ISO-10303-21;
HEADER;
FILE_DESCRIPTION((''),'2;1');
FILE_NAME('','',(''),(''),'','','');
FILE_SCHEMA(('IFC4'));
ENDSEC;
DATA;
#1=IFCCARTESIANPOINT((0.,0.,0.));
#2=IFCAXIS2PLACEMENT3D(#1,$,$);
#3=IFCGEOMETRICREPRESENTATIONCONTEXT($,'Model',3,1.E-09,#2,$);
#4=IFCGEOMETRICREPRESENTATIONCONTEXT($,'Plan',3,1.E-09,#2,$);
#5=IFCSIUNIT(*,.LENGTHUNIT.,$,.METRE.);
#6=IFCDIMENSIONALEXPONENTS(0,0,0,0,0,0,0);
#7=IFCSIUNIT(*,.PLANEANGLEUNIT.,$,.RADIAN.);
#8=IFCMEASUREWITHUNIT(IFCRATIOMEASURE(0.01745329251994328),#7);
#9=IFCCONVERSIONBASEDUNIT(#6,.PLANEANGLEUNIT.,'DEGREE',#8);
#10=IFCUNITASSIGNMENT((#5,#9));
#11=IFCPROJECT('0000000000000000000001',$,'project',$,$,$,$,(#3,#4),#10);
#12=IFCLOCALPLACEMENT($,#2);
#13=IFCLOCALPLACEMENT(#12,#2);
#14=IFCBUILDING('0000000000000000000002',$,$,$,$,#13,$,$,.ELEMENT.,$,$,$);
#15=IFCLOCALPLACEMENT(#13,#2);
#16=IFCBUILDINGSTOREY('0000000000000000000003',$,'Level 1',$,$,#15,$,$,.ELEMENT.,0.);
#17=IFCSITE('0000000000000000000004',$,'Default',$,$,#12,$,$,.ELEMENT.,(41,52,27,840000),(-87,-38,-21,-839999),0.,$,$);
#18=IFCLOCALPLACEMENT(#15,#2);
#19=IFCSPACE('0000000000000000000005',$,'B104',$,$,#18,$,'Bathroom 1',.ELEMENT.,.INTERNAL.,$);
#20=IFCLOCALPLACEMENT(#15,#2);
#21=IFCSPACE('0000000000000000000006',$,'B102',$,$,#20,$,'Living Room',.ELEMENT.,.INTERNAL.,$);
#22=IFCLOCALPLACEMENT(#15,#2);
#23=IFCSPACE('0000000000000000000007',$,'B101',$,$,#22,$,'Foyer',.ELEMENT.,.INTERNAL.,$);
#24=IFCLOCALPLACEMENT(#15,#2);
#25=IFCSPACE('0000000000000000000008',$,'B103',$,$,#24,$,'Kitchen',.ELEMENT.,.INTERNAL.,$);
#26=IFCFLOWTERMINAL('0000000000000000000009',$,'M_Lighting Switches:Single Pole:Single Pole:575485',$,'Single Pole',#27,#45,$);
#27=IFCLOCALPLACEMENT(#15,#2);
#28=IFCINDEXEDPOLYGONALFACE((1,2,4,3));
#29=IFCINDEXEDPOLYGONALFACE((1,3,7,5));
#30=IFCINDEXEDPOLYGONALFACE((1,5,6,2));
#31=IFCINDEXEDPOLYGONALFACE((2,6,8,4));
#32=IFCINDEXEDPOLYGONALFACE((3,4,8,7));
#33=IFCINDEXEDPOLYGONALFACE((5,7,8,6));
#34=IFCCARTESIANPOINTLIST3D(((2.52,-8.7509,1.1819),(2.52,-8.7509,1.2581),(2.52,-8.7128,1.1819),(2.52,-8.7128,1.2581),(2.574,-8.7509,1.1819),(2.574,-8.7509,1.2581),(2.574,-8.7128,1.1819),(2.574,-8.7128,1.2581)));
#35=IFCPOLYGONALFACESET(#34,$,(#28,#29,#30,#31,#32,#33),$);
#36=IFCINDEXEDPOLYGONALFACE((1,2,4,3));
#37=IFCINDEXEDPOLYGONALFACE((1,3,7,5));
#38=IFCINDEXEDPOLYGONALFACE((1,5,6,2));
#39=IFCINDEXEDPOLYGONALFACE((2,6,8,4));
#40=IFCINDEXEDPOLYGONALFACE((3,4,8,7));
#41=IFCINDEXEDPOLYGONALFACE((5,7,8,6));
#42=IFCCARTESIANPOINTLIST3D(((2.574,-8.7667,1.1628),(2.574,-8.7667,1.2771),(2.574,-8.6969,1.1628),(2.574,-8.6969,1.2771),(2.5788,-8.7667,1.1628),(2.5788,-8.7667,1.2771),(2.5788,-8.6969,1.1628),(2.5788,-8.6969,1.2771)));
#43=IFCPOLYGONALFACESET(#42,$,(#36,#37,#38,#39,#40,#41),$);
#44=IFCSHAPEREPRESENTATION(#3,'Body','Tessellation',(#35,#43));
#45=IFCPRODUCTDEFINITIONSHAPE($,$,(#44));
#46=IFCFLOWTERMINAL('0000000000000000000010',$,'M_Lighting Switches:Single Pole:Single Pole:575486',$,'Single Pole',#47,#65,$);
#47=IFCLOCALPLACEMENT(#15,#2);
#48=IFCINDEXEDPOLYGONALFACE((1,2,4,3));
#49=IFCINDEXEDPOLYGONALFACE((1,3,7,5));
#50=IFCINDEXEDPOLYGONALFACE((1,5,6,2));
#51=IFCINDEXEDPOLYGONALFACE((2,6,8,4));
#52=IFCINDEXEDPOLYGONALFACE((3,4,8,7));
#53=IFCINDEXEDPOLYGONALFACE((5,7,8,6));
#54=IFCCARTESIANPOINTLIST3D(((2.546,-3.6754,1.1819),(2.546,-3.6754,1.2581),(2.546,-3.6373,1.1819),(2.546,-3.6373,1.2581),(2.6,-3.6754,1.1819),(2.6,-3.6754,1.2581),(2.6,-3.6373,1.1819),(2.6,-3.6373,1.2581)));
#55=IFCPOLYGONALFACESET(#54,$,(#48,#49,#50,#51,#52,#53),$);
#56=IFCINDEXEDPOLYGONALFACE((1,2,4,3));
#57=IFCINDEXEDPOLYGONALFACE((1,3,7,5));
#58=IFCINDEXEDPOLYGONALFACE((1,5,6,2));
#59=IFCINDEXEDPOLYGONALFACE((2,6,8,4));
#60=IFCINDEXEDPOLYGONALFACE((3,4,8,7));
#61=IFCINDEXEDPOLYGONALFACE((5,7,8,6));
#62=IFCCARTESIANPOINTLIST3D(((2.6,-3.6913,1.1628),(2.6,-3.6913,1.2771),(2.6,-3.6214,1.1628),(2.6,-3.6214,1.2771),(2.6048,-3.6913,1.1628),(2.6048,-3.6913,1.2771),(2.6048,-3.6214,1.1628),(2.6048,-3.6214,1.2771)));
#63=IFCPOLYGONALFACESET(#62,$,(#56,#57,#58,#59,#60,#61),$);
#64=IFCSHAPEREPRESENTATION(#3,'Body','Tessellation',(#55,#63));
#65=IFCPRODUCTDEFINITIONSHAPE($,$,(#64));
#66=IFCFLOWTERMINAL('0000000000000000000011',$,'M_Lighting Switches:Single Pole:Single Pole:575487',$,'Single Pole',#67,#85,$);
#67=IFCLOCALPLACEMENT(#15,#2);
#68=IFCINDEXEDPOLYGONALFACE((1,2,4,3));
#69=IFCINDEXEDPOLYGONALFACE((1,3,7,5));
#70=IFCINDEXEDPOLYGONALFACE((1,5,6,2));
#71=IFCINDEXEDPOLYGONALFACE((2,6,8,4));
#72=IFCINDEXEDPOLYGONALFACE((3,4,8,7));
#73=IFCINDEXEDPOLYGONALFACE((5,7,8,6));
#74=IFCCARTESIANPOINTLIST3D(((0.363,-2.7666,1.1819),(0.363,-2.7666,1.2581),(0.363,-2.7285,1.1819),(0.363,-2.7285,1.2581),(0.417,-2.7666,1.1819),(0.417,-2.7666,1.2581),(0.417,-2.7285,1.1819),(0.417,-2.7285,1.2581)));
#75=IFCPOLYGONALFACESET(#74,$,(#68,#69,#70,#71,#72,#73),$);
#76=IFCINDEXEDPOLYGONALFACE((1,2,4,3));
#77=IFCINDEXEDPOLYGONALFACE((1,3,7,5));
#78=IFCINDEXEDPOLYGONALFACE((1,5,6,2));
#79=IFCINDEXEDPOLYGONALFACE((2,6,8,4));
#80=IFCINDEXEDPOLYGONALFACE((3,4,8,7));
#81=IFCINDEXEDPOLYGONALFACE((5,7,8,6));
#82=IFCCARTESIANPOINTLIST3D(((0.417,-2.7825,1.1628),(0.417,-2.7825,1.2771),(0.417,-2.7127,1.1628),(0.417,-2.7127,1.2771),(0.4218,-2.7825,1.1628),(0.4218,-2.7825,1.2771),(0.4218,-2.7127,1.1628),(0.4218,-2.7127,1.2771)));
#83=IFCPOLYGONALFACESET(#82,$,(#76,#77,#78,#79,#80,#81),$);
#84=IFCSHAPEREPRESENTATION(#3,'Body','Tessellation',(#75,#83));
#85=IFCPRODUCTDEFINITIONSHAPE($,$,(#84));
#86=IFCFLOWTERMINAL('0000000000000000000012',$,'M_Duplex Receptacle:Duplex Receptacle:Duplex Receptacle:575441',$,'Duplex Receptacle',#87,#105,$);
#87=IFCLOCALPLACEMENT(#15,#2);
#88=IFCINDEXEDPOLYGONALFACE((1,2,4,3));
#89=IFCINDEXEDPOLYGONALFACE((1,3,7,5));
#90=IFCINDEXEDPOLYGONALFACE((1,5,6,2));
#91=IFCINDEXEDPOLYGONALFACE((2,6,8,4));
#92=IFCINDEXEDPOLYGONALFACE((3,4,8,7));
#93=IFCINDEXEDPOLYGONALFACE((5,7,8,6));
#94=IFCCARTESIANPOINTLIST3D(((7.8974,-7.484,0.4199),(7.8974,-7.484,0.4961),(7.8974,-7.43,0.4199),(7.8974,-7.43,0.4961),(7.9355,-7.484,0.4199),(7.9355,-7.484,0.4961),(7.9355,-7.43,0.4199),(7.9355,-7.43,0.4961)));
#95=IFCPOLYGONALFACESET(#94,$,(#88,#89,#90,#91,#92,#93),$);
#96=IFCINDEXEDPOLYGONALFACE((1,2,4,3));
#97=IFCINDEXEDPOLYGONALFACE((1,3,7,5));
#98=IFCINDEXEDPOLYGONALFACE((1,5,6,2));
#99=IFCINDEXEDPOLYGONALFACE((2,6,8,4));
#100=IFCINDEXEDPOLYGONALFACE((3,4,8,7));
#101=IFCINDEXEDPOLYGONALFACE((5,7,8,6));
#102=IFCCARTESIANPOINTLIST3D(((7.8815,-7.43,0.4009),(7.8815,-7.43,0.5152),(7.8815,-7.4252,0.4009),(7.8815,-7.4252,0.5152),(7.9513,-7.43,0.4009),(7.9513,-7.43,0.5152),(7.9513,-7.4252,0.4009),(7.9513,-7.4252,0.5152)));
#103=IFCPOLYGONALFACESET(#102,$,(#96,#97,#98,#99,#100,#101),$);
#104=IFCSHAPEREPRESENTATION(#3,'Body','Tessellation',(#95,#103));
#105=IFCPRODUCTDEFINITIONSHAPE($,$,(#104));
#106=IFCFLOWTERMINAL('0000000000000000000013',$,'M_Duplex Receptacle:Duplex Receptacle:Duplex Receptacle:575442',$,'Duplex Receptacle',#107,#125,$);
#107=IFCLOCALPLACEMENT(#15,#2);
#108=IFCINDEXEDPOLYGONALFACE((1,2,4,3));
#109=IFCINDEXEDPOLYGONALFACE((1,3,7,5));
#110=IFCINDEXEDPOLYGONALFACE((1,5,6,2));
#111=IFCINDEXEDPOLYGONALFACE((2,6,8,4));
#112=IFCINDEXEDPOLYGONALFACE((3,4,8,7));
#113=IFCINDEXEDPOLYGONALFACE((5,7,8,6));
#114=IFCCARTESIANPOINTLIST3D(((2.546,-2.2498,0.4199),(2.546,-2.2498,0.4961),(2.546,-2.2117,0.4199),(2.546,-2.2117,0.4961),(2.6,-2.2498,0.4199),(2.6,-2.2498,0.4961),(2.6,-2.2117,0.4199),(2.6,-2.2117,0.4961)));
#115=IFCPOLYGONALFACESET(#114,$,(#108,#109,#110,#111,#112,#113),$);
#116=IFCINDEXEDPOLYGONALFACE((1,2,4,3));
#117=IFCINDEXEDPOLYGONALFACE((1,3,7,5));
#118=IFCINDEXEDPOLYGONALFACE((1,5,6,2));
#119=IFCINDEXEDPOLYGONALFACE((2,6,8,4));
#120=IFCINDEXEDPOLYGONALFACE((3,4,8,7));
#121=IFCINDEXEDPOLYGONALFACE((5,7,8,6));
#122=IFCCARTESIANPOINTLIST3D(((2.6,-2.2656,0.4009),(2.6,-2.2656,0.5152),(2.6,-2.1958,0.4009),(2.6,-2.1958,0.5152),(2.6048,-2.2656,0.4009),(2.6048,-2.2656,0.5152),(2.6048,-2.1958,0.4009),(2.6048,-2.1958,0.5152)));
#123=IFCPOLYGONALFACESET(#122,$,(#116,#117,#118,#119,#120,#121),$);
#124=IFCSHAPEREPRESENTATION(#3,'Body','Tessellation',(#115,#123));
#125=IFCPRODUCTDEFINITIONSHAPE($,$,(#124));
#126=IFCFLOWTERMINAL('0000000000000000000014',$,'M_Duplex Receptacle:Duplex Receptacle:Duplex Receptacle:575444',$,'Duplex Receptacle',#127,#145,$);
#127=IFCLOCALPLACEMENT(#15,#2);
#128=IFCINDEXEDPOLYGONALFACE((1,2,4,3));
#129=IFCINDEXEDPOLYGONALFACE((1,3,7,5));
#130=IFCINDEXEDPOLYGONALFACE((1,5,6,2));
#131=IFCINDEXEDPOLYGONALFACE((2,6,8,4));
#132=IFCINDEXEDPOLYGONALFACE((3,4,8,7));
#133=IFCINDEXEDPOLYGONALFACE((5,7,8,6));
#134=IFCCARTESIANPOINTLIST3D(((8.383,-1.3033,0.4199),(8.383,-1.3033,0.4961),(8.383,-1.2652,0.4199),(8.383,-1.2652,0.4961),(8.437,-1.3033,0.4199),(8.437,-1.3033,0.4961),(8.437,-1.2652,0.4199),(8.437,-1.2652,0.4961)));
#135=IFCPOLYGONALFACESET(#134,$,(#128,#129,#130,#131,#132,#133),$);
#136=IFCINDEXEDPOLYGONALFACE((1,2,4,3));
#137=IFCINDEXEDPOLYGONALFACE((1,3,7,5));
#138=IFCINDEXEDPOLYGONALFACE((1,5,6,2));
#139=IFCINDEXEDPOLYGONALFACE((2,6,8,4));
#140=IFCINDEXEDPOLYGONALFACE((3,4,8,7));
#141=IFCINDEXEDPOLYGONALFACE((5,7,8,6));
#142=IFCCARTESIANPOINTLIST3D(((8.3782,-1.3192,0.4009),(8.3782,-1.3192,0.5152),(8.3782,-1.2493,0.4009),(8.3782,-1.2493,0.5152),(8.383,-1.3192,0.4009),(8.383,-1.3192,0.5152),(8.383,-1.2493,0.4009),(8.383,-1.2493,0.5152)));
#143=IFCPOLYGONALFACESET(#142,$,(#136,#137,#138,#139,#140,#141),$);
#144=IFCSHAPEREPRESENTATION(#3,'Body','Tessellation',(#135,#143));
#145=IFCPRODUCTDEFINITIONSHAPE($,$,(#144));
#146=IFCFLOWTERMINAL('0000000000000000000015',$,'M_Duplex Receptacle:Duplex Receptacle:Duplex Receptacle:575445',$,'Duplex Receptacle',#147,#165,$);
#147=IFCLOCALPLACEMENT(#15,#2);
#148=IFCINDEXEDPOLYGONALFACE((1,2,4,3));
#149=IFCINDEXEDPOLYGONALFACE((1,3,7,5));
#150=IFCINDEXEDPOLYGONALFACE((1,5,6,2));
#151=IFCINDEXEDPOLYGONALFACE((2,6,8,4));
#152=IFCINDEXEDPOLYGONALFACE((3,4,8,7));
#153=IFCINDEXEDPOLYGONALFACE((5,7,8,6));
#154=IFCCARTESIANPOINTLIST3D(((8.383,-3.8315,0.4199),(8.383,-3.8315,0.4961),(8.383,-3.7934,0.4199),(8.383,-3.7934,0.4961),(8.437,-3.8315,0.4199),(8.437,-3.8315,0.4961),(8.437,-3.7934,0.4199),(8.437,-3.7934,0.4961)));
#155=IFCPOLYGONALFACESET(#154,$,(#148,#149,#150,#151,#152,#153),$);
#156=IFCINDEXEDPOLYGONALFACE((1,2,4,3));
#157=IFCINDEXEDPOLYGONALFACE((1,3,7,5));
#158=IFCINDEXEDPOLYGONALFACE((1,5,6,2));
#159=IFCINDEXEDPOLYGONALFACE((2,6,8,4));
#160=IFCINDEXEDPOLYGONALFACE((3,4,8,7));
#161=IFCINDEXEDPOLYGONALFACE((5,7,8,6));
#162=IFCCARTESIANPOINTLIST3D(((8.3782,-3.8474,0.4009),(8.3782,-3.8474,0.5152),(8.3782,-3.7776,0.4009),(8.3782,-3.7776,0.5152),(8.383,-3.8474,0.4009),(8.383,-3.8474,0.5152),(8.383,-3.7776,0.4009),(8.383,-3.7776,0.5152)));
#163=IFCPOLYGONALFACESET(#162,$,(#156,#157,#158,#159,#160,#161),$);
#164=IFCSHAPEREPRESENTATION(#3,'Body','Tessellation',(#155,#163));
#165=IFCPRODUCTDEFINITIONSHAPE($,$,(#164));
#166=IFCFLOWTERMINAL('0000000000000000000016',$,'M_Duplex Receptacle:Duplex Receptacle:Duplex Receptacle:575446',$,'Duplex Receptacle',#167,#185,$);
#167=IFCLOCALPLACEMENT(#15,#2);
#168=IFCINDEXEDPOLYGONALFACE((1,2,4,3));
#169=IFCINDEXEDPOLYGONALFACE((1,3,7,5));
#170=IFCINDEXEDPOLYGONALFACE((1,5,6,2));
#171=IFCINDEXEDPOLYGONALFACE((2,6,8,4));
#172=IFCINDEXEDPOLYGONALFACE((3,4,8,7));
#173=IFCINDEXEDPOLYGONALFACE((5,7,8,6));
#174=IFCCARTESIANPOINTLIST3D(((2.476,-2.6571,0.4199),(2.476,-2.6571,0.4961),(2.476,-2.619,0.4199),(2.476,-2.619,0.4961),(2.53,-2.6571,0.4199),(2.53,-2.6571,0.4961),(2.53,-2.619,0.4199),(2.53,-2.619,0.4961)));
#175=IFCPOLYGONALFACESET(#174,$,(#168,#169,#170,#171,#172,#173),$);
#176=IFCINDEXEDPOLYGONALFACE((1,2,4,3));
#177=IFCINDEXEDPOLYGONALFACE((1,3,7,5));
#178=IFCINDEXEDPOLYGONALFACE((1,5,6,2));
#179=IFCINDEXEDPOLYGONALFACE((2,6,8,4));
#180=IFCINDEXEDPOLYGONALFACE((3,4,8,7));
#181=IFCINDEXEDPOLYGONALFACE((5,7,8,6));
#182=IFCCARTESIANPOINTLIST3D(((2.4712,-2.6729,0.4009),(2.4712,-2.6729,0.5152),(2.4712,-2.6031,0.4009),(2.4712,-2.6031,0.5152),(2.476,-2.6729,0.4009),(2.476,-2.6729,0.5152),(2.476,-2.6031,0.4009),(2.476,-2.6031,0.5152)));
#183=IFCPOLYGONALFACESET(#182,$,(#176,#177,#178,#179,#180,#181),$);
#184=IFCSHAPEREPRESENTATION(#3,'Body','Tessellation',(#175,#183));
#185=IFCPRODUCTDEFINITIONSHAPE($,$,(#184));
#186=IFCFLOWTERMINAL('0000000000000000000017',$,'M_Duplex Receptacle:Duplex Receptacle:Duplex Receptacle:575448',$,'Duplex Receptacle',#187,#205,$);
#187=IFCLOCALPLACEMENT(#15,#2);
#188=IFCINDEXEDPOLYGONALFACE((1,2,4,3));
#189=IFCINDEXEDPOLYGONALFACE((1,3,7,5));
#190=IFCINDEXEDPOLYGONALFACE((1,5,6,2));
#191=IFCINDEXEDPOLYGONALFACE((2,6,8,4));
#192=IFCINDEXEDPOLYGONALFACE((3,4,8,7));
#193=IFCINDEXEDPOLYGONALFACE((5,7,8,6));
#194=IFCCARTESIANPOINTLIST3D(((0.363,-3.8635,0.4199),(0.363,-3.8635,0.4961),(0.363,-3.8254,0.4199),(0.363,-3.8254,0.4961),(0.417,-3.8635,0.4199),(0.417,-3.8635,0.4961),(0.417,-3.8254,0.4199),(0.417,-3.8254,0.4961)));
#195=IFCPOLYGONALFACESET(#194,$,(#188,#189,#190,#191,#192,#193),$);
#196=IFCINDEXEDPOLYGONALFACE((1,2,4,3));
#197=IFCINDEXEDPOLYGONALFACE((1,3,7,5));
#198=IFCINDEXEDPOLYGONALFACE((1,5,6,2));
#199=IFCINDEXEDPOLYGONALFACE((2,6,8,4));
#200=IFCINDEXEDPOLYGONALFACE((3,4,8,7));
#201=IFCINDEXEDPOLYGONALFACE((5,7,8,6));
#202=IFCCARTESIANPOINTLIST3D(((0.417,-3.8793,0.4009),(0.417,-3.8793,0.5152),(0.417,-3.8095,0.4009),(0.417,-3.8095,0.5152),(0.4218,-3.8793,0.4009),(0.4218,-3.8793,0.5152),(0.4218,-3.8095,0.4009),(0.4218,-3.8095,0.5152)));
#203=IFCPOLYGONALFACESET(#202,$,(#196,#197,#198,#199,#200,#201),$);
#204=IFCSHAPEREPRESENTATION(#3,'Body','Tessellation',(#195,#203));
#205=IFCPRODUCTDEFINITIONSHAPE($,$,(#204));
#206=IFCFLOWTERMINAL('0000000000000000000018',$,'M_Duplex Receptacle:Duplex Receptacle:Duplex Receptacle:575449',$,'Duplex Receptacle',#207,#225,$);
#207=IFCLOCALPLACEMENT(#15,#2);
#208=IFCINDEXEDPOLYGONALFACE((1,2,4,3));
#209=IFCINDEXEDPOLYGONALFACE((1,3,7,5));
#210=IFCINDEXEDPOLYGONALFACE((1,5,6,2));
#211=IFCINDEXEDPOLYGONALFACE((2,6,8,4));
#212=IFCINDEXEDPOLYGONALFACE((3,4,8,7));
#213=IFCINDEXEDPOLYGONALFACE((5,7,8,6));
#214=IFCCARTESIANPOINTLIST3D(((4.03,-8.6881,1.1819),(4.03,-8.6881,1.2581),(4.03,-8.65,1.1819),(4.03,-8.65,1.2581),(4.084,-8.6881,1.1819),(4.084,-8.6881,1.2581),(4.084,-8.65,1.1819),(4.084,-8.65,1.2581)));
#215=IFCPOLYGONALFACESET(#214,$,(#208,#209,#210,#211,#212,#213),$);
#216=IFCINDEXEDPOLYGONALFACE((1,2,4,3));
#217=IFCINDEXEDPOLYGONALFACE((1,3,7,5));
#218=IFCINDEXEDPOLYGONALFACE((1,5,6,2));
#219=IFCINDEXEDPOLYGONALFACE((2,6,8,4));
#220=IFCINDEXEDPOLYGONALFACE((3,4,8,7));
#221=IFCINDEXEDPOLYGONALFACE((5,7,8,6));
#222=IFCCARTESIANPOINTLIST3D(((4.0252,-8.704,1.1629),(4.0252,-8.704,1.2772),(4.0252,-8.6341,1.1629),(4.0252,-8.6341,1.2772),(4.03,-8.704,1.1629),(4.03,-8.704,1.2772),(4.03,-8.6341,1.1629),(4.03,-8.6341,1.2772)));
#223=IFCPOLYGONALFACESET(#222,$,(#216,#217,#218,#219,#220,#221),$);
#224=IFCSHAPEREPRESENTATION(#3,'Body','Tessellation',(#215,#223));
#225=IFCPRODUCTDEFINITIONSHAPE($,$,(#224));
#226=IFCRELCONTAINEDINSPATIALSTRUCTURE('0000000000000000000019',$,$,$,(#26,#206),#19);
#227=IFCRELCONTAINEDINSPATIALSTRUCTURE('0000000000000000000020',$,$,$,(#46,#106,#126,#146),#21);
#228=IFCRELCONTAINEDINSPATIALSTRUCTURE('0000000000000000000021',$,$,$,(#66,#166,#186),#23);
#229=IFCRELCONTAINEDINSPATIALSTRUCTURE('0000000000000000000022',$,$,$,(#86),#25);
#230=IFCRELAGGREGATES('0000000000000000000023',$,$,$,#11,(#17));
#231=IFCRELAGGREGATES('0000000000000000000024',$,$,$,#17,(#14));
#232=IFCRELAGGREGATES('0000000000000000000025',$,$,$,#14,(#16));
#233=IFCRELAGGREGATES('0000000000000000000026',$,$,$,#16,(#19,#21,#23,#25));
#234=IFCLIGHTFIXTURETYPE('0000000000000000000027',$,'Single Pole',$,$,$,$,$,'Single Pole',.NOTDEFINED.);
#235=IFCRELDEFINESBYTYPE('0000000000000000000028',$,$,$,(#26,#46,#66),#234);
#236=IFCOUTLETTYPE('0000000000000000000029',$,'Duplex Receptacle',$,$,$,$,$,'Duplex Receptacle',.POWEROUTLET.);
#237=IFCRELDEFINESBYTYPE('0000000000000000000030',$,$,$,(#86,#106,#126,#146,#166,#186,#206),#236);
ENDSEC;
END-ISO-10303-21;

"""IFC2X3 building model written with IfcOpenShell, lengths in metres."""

from ifc_helpers import new_model, entity, si_unit, converted_unit, frame, origin, origin_2d_with_axis, place, context, project, spatial, rectangle, extrude, source, transform, mapped, type_object, type_shapes, element, save


model = new_model("IFC2X3")

# Units and contexts
model_context = context("Model", 3, precision=1e-09, world=origin())
plan_context = context("Plan", 3, precision=1e-09, world=origin())
ifc_project = project(units=[si_unit("LENGTHUNIT", "METRE"), converted_unit("PLANEANGLEUNIT", "DEGREE", entity("IfcRatioMeasure", 0.01745329251994328), si_unit("PLANEANGLEUNIT", "RADIAN"), dimensions=[0, 0, 0, 0, 0, 0, 0])], contexts=[model_context, plan_context])

# Site, building, storey, space
site_placement = place(None, origin())
site = spatial("IfcSite", under=ifc_project, at=site_placement, Name="Default", CompositionType="ELEMENT", RefLatitude=(41, 52, 27, 840000), RefLongitude=(-87, -38, -21, -839999), RefElevation=0.0)
building_placement = place(site_placement, origin())
building = spatial("IfcBuilding", under=site, at=building_placement, CompositionType="ELEMENT")
storey_placement = place(building_placement, origin())
storey = spatial("IfcBuildingStorey", under=building, at=storey_placement, Name="Level 1", CompositionType="ELEMENT", Elevation=0.0)
space_1_placement = place(storey_placement, origin())
space_1 = spatial("IfcSpace", under=storey, at=space_1_placement, Name="B104", LongName="Bathroom 1", CompositionType="ELEMENT", InteriorOrExteriorSpace="INTERNAL")

# Flow terminal
light_fixture_type = type_object("IfcLightFixtureType", Name="Single Pole", ElementType="Single Pole", PredefinedType="NOTDEFINED")
shared_shape_1 = source(origin(), model_context, "Body", "SweptSolid", [
    extrude(rectangle(XDim=0.0381, YDim=0.0762, at=origin_2d_with_axis()), frame((0.0, 0.0, -0.054), z_axis=(0.0, 0.0, 1.0), x_axis=(-1.0, 0.0, 0.0)), (0.0, 0.0, 1.0), 0.054),
    extrude(rectangle(XDim=0.0698, YDim=0.1143, at=origin_2d_with_axis()), frame((0.0, 0.0, 0.0), z_axis=(0.0, 0.0, 1.0), x_axis=(-1.0, 0.0, 0.0)), (0.0, 0.0, 1.0), 0.0048),
])
type_shapes(light_fixture_type, [shared_shape_1])
flow_terminal_1_placement = place(space_1_placement, frame((2.574, -8.7318, 1.22), z_axis=(1.0, 0.0, 0.0), x_axis=(0.0, 1.0, 0.0)))
element("IfcFlowTerminal", 1, at=flow_terminal_1_placement, inside=space_1, type_object=light_fixture_type, Name="M_Lighting Switches:Single Pole:Single Pole:575485", ObjectType="Single Pole", context=model_context, shape_type="MappedRepresentation", body=[
    mapped(shared_shape_1, transform((0.0, 0.0, 0.0), scale=1.0)),
])

# Shared definitions
space_2_placement = place(storey_placement, origin())
space_2 = spatial("IfcSpace", under=storey, at=space_2_placement, Name="B102", LongName="Living Room", CompositionType="ELEMENT", InteriorOrExteriorSpace="INTERNAL")

# Flow terminal
flow_terminal_2_placement = place(space_2_placement, frame((2.6, -3.6564, 1.22), z_axis=(1.0, 0.0, 0.0), x_axis=(0.0, 1.0, 0.0)))
element("IfcFlowTerminal", 2, at=flow_terminal_2_placement, inside=space_2, type_object=light_fixture_type, Name="M_Lighting Switches:Single Pole:Single Pole:575486", ObjectType="Single Pole", context=model_context, shape_type="MappedRepresentation", body=[
    mapped(shared_shape_1, transform((0.0, 0.0, 0.0), scale=1.0)),
])

# Shared definitions
space_3_placement = place(storey_placement, origin())
space_3 = spatial("IfcSpace", under=storey, at=space_3_placement, Name="B101", LongName="Foyer", CompositionType="ELEMENT", InteriorOrExteriorSpace="INTERNAL")

# Flow terminal
flow_terminal_3_placement = place(space_3_placement, frame((0.417, -2.7476, 1.22), z_axis=(1.0, 0.0, 0.0), x_axis=(0.0, 1.0, 0.0)))
element("IfcFlowTerminal", 3, at=flow_terminal_3_placement, inside=space_3, type_object=light_fixture_type, Name="M_Lighting Switches:Single Pole:Single Pole:575487", ObjectType="Single Pole", context=model_context, shape_type="MappedRepresentation", body=[
    mapped(shared_shape_1, transform((0.0, 0.0, 0.0), scale=1.0)),
])

# Shared definitions
space_4_placement = place(storey_placement, origin())
space_4 = spatial("IfcSpace", under=storey, at=space_4_placement, Name="B103", LongName="Kitchen", CompositionType="ELEMENT", InteriorOrExteriorSpace="INTERNAL")

# Flow terminals
outlet_type = type_object("IfcOutletType", Name="Duplex Receptacle", ElementType="Duplex Receptacle", PredefinedType="POWEROUTLET")
shared_shape_2 = source(origin(), model_context, "Body", "SweptSolid", [
    extrude(rectangle(XDim=0.0381, YDim=0.0762, at=origin_2d_with_axis()), frame((0.0, 0.0, -0.054), z_axis=(0.0, 0.0, 1.0), x_axis=(-1.0, 0.0, 0.0)), (0.0, 0.0, 1.0), 0.054),
    extrude(rectangle(XDim=0.0698, YDim=0.1143, at=origin_2d_with_axis()), frame((0.0, 0.0, 0.0), z_axis=(0.0, 0.0, 1.0), x_axis=(-1.0, 0.0, 0.0)), (0.0, 0.0, 1.0), 0.0048),
])
type_shapes(outlet_type, [shared_shape_2])
flow_terminal_4_placement = place(space_4_placement, frame((7.9164, -7.43, 0.458), z_axis=(0.0, 1.0, 0.0), x_axis=(-1.0, 0.0, 0.0)))
element("IfcFlowTerminal", 4, at=flow_terminal_4_placement, inside=space_4, type_object=outlet_type, Name="M_Duplex Receptacle:Duplex Receptacle:Duplex Receptacle:575441", ObjectType="Duplex Receptacle", context=model_context, shape_type="MappedRepresentation", body=[
    mapped(shared_shape_2, transform((0.0, 0.0, 0.0), scale=1.0)),
])
for number, where, z_axis, x_axis, name in (
    (5, (2.6, -2.2307, 0.458), (1.0, 0.0, 0.0), (0.0, 1.0, 0.0), "M_Duplex Receptacle:Duplex Receptacle:Duplex Receptacle:575442"),
    (6, (8.383, -1.2842, 0.458), (-1.0, 0.0, 0.0), (0.0, -1.0, 0.0), "M_Duplex Receptacle:Duplex Receptacle:Duplex Receptacle:575444"),
    (7, (8.383, -3.8125, 0.458), (-1.0, 0.0, 0.0), (0.0, -1.0, 0.0), "M_Duplex Receptacle:Duplex Receptacle:Duplex Receptacle:575445"),
):
    element("IfcFlowTerminal", number, at=place(space_2_placement, frame(where, z_axis=z_axis, x_axis=x_axis)), inside=space_2, type_object=outlet_type, Name=name, ObjectType="Duplex Receptacle", context=model_context, shape_type="MappedRepresentation", body=[
        mapped(shared_shape_2, transform((0.0, 0.0, 0.0), scale=1.0)),
    ])
for number, where, z_axis, x_axis, name in (
    (8, (2.476, -2.638, 0.458), (-1.0, 0.0, 0.0), (0.0, -1.0, 0.0), "M_Duplex Receptacle:Duplex Receptacle:Duplex Receptacle:575446"),
    (9, (0.417, -3.8444, 0.458), (1.0, 0.0, 0.0), (0.0, 1.0, 0.0), "M_Duplex Receptacle:Duplex Receptacle:Duplex Receptacle:575448"),
):
    element("IfcFlowTerminal", number, at=place(space_3_placement, frame(where, z_axis=z_axis, x_axis=x_axis)), inside=space_3, type_object=outlet_type, Name=name, ObjectType="Duplex Receptacle", context=model_context, shape_type="MappedRepresentation", body=[
        mapped(shared_shape_2, transform((0.0, 0.0, 0.0), scale=1.0)),
    ])
flow_terminal_5_placement = place(space_1_placement, frame((4.03, -8.6691, 1.22), z_axis=(-1.0, 0.0, 0.0), x_axis=(0.0, -1.0, 0.0)))
element("IfcFlowTerminal", 10, at=flow_terminal_5_placement, inside=space_1, type_object=outlet_type, Name="M_Duplex Receptacle:Duplex Receptacle:Duplex Receptacle:575449", ObjectType="Duplex Receptacle", context=model_context, shape_type="MappedRepresentation", body=[
    mapped(shared_shape_2, transform((0.0, 0.0, 0.0), scale=1.0)),
])

save(model, "model.ifc")
